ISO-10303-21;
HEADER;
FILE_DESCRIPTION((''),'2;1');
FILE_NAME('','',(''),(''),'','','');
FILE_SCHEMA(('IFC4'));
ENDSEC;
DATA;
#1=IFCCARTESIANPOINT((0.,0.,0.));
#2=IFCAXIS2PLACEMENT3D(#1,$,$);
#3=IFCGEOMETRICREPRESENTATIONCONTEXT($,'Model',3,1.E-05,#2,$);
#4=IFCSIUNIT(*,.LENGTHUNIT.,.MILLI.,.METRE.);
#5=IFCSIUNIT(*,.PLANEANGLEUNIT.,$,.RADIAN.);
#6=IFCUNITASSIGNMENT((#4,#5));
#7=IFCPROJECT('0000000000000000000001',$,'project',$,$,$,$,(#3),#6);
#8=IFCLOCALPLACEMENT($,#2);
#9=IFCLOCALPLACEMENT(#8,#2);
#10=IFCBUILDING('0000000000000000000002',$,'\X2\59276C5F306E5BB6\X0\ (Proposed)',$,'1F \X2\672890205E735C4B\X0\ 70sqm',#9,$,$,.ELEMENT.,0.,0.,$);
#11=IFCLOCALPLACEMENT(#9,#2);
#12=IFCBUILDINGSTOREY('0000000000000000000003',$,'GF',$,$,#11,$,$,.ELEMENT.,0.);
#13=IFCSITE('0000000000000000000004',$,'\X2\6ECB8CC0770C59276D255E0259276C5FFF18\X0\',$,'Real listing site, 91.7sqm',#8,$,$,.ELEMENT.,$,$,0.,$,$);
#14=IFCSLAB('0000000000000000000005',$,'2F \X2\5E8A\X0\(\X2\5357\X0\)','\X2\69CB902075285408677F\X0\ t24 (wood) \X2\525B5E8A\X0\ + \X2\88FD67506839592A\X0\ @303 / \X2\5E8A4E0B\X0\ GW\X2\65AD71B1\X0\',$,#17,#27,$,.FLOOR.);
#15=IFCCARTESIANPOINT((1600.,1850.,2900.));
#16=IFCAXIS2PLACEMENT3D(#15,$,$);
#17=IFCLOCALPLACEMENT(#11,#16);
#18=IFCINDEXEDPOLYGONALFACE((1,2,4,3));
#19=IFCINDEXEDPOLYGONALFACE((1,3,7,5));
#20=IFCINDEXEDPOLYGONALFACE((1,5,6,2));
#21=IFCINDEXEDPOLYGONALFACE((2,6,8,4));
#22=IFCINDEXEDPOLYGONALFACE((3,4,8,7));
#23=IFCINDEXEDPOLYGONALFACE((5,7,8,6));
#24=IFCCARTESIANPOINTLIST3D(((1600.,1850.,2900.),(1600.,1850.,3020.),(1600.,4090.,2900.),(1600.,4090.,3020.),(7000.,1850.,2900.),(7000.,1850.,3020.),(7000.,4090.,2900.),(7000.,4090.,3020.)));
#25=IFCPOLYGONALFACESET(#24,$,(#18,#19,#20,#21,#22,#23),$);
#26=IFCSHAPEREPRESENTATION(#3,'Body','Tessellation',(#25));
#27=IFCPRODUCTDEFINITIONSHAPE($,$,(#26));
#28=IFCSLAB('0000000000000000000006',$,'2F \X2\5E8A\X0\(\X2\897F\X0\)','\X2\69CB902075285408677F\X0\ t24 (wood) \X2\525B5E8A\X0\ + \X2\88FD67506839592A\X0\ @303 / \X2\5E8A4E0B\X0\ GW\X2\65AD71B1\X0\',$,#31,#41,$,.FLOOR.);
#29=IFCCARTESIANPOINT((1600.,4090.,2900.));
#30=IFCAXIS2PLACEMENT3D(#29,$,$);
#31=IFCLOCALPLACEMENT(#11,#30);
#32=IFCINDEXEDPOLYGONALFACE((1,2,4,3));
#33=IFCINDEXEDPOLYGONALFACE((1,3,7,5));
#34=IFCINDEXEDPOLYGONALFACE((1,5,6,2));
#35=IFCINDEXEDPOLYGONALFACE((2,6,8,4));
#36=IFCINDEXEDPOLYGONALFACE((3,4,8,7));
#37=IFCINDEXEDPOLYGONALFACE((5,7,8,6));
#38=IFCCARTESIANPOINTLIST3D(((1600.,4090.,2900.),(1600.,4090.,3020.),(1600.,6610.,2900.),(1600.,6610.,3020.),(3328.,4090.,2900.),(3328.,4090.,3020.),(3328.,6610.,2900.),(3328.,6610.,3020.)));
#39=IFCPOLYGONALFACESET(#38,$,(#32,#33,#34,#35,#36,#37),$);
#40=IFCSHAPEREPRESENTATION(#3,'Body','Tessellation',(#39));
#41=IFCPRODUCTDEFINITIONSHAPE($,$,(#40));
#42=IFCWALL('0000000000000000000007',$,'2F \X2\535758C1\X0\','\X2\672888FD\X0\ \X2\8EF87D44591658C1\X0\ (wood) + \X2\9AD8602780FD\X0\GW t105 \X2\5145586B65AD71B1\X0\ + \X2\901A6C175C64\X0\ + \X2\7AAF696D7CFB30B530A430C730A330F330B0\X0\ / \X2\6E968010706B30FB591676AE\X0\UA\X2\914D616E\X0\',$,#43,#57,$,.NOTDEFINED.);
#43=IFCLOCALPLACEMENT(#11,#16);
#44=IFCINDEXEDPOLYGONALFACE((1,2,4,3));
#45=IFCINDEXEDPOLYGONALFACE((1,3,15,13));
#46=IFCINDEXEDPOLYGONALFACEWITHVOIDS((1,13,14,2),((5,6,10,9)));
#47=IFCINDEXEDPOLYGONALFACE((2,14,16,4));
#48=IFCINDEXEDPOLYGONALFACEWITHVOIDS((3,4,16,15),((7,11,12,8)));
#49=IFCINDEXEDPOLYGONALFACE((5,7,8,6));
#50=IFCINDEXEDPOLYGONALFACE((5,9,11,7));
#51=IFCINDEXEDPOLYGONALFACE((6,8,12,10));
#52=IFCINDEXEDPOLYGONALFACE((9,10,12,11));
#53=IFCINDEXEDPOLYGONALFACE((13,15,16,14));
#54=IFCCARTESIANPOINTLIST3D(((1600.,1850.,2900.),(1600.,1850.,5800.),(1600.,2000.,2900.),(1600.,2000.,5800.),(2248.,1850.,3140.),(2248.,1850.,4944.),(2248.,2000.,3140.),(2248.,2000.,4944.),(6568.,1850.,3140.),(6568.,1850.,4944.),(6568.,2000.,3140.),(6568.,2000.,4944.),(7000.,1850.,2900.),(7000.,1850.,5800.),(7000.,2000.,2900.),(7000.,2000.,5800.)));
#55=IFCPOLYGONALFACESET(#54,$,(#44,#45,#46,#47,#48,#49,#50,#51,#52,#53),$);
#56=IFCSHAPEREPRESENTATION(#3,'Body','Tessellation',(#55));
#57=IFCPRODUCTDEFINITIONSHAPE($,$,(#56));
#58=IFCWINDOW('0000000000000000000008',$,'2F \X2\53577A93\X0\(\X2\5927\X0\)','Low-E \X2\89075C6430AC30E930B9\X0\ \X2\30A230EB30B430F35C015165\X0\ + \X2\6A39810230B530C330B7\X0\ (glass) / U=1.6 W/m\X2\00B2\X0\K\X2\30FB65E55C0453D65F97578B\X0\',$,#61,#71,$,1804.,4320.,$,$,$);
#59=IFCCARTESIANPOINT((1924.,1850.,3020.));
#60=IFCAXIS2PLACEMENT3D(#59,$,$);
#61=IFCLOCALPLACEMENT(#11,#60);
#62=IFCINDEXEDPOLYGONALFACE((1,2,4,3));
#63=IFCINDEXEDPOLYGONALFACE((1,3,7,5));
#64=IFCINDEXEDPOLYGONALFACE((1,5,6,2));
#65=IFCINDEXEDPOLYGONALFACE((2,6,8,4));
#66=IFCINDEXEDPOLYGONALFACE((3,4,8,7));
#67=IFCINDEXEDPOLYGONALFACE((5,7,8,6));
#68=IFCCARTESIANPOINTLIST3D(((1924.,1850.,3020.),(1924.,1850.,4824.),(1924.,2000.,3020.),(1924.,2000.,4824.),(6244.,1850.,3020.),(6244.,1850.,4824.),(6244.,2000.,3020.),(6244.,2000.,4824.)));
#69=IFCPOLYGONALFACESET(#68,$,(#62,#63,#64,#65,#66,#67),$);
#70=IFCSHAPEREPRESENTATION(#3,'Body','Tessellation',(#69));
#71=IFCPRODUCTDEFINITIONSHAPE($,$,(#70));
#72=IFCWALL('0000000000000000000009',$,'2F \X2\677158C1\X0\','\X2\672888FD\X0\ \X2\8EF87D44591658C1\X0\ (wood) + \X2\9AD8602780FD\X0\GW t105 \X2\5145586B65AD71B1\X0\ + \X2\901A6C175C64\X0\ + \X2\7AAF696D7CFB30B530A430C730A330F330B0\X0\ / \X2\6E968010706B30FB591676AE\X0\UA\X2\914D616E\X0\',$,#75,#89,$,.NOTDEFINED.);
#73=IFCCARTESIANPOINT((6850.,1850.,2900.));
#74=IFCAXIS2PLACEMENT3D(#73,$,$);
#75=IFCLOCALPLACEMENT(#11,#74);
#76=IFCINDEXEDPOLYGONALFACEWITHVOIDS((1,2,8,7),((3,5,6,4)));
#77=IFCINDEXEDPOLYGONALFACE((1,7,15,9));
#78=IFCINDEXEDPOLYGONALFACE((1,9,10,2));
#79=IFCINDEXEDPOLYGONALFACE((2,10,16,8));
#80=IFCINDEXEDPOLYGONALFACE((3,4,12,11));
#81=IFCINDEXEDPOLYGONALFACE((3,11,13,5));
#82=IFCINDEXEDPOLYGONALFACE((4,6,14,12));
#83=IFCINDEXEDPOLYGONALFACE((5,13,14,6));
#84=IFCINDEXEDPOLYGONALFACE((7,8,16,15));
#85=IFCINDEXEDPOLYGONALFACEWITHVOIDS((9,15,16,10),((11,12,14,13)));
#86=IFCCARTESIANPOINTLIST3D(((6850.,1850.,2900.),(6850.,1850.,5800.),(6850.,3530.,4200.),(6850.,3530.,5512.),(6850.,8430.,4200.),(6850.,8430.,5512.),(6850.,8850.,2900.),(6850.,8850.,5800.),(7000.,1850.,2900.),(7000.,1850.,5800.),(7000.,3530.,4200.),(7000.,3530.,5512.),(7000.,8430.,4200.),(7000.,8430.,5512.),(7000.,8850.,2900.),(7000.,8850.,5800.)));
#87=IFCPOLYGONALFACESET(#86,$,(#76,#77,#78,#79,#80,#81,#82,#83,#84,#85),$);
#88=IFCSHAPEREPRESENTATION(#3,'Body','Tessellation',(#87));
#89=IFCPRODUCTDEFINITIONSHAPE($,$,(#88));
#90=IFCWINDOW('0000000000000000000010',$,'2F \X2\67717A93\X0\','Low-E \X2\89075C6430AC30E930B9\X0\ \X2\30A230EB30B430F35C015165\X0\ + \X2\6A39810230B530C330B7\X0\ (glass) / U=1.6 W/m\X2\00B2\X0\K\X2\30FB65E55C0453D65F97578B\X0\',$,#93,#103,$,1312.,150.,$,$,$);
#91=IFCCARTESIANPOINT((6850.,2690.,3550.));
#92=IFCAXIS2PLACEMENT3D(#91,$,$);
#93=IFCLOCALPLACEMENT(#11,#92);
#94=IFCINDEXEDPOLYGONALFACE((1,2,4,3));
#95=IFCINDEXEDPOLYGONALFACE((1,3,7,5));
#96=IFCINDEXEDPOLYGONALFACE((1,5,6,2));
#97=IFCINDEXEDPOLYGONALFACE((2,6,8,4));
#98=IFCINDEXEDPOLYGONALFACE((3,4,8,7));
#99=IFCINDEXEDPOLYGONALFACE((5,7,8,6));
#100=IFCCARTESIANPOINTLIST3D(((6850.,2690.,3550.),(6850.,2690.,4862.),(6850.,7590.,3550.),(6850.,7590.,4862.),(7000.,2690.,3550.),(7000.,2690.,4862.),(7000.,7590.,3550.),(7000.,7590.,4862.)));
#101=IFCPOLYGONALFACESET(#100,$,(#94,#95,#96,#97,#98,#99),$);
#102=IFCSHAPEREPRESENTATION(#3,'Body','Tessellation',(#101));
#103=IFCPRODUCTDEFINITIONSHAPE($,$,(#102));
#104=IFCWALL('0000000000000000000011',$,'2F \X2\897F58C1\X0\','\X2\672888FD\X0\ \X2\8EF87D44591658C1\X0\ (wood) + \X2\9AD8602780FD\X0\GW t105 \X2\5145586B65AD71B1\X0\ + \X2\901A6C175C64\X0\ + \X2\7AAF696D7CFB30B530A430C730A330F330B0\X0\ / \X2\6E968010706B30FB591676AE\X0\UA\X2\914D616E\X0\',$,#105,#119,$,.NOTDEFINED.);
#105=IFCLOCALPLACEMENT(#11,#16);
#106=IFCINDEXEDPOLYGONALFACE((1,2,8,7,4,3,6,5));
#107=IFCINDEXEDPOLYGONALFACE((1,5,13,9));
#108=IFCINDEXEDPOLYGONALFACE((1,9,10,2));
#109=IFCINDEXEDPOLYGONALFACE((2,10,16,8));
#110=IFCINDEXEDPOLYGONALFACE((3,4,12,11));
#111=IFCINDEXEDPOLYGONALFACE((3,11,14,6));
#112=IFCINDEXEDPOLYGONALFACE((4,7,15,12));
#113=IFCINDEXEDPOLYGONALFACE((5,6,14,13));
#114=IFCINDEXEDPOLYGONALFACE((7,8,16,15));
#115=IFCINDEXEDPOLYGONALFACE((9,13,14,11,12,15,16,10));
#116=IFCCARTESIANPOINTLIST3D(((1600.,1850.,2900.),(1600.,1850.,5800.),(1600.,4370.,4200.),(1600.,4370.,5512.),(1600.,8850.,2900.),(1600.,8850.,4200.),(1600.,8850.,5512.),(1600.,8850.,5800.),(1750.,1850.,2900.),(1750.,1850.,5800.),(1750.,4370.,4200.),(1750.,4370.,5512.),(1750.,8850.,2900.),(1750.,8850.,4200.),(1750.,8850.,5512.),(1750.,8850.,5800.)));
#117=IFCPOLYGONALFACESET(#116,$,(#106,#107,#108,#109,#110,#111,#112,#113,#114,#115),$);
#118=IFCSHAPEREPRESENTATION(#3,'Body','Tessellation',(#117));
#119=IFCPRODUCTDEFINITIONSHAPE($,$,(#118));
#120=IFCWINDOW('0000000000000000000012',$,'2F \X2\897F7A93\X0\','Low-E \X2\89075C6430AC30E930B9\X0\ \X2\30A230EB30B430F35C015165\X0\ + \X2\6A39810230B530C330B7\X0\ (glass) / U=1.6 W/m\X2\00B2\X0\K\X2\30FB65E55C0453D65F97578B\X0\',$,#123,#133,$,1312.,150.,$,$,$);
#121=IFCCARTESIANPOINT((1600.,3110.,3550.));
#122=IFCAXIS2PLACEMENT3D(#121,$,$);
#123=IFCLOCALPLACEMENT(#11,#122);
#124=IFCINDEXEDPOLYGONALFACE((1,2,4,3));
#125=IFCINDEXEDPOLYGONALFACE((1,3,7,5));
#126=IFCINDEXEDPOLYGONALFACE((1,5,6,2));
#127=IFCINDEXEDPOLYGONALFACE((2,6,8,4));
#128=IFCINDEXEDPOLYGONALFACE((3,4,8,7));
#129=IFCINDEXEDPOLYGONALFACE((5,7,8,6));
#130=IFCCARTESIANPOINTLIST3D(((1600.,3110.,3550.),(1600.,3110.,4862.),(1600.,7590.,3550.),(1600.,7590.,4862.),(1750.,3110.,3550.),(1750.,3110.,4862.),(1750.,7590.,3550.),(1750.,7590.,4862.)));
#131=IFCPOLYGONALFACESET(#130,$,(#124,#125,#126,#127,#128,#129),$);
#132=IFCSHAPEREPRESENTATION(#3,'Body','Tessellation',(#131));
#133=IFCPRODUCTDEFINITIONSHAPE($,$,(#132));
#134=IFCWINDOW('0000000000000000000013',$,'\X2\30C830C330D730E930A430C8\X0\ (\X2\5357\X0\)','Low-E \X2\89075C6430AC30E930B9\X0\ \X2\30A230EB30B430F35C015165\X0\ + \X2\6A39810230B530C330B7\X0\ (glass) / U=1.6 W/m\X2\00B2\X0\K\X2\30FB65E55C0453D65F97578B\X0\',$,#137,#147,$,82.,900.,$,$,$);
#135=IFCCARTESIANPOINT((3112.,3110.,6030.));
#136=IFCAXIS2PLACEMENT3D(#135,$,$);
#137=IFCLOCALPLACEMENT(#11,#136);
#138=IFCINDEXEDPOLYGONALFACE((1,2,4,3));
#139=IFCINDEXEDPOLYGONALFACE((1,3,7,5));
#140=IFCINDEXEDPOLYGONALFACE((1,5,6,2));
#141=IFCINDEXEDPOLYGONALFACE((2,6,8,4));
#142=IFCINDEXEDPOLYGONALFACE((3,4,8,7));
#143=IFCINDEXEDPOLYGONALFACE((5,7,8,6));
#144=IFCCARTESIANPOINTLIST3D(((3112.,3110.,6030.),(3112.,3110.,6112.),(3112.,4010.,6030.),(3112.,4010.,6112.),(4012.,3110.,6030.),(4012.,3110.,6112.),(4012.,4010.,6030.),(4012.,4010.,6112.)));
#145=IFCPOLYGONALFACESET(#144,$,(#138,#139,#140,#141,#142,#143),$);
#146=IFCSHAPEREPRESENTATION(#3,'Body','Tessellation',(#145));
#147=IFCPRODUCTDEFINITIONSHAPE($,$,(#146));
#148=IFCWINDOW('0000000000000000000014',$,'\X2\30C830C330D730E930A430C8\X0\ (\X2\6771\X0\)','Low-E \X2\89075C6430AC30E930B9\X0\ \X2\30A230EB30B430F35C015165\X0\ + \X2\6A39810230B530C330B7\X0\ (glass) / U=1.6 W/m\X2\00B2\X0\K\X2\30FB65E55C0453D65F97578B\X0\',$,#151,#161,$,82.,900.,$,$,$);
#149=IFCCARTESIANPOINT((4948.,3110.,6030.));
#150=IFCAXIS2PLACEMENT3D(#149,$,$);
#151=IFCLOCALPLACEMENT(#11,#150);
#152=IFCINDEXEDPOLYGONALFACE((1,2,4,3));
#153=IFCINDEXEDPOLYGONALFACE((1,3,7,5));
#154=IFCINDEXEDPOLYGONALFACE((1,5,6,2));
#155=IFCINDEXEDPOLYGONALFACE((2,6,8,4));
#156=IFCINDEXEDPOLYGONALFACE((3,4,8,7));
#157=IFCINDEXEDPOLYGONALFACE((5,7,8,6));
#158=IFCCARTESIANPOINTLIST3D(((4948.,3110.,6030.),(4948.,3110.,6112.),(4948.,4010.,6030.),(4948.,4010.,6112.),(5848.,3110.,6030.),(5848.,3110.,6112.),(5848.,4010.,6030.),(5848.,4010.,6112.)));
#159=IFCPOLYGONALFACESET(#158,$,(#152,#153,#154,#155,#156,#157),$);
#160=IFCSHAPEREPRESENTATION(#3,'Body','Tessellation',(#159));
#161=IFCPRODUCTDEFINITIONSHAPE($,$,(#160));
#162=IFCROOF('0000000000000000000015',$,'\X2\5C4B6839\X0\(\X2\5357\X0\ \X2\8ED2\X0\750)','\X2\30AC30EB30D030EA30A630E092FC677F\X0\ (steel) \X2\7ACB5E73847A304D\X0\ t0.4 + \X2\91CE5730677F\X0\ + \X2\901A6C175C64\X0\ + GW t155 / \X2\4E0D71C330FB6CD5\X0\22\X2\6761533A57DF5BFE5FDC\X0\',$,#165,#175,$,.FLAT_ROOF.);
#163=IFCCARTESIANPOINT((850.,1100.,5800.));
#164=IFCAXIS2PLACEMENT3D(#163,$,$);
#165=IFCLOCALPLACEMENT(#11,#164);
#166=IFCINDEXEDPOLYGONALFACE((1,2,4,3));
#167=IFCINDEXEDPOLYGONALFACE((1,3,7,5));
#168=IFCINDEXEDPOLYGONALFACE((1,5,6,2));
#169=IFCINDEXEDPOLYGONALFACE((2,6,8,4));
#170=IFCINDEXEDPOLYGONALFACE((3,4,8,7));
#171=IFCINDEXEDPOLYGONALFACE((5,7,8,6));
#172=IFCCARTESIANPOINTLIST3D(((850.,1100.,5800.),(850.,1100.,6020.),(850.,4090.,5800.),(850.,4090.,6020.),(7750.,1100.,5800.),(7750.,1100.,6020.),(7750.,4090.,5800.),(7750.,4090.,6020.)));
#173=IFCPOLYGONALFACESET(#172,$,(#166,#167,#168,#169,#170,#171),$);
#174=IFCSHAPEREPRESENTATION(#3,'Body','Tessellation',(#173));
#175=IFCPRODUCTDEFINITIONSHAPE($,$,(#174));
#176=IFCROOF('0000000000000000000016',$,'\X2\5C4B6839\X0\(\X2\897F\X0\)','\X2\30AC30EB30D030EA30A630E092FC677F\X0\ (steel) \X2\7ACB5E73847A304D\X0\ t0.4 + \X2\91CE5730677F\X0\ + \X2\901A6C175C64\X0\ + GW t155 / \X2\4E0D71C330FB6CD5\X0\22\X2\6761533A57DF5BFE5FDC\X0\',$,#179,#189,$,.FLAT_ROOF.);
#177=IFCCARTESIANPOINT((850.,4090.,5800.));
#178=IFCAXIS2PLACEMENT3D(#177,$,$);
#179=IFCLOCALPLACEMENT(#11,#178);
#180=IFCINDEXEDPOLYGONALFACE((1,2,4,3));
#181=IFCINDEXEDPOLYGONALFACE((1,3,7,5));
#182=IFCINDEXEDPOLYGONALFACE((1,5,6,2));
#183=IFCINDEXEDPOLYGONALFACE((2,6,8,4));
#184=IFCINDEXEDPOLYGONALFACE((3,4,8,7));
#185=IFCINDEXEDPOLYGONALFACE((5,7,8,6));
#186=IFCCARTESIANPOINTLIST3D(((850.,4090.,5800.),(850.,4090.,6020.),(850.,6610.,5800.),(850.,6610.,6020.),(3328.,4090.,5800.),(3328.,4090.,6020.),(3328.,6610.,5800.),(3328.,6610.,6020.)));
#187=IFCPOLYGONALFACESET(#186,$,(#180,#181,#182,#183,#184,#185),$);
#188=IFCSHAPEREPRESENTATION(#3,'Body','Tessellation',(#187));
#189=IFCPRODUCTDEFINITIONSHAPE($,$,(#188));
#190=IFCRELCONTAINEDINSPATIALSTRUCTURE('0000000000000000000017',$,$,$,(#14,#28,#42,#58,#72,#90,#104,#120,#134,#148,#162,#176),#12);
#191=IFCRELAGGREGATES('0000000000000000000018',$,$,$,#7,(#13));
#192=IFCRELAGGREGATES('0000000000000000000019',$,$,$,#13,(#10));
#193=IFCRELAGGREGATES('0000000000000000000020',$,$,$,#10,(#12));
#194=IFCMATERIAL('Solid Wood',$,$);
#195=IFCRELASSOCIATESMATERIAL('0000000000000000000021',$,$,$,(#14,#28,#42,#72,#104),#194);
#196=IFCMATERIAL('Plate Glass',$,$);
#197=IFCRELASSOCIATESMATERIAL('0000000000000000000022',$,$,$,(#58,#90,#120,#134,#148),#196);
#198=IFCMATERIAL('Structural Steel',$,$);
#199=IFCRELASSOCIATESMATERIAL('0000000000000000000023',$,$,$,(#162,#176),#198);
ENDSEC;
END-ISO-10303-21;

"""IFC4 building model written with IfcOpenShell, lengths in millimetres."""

from ifc_helpers import new_model, si_unit, frame, frame_2d, origin, place, context, project, spatial, rectangle, extrude, material, element, fill, save


model = new_model("IFC4")

# Units and contexts
model_context = context("Model", 3, precision=1e-05, world=origin())
ifc_project = project(units=[si_unit("LENGTHUNIT", "METRE", prefix="MILLI"), si_unit("PLANEANGLEUNIT", "RADIAN")], contexts=[model_context])

# Site, building, storey
site_placement = place(None, origin())
site = spatial("IfcSite", under=ifc_project, at=site_placement, Name="滋賀県大津市大江８", ObjectType="Real listing site, 91.7sqm", CompositionType="ELEMENT", RefElevation=0.0)
building_placement = place(site_placement, origin())
building = spatial("IfcBuilding", under=site, at=building_placement, Name="大江の家 (Proposed)", ObjectType="1F 木造平屋 70sqm", CompositionType="ELEMENT", ElevationOfRefHeight=0.0, ElevationOfTerrain=0.0)
storey_placement = place(building_placement, origin())
storey = spatial("IfcBuildingStorey", under=building, at=storey_placement, Name="GF", CompositionType="ELEMENT", Elevation=0.0)

# Slabs
ifc_material_1 = material(Name="Solid Wood")
slab_1_placement = place(storey_placement, frame((1600.0, 1850.0, 2900.0)))
element("IfcSlab", 1, at=slab_1_placement, inside=storey, material=ifc_material_1, Name="2F 床(南)", Description="構造用合板 t24 (wood) 剛床 + 製材根太 @303 / 床下 GW断熱", PredefinedType="FLOOR", context=model_context, shape_type="SweptSolid", body=[
    extrude(rectangle(XDim=5400.0, YDim=2240.0, at=frame_2d((2700.0, 1120.0))), frame((1600.0, 1850.0, 2900.0)), (0.0, 0.0, 1.0), 120.0),
])
slab_2_placement = place(storey_placement, frame((1600.0, 4090.0, 2900.0)))
element("IfcSlab", 2, at=slab_2_placement, inside=storey, material=ifc_material_1, Name="2F 床(西)", Description="構造用合板 t24 (wood) 剛床 + 製材根太 @303 / 床下 GW断熱", PredefinedType="FLOOR", context=model_context, shape_type="SweptSolid", body=[
    extrude(rectangle(XDim=1728.0, YDim=2520.0, at=frame_2d((864.0, 1260.0))), frame((1600.0, 4090.0, 2900.0)), (0.0, 0.0, 1.0), 120.0),
])

# Walls, openings, windows
wall_1_placement = place(storey_placement, frame((1600.0, 1850.0, 2900.0)))
wall_1 = element("IfcWall", 3, at=wall_1_placement, inside=storey, material=ifc_material_1, Name="2F 南壁", Description="木製 軸組外壁 (wood) + 高性能GW t105 充填断熱 + 通気層 + 窯業系サイディング / 準耐火・外皮UA配慮", PredefinedType="NOTDEFINED", context=model_context, shape_type="SweptSolid", body=[
    extrude(rectangle(XDim=5400.0, YDim=150.0, at=frame_2d((2700.0, 75.0))), frame((1600.0, 1850.0, 2900.0)), (0.0, 0.0, 1.0), 2900.0),
])
opening_1_placement = place(storey_placement, frame((1924.0, 1850.0, 3020.0)))
opening_1 = element("IfcOpeningElement", 4, at=opening_1_placement, cuts=wall_1, PredefinedType="NOTDEFINED", context=model_context, shape_type="SweptSolid", body=[
    extrude(rectangle(XDim=4320.0, YDim=150.0, at=frame_2d((2160.0, 75.0))), frame((1924.0, 1850.0, 3020.0)), (0.0, 0.0, 1.0), 1804.0),
])
ifc_material_2 = material(Name="Plate Glass")
window_1_placement = place(storey_placement, frame((1924.0, 1850.0, 3020.0)))
window_1 = element("IfcWindow", 5, at=window_1_placement, inside=storey, material=ifc_material_2, Name="2F 南窓(大)", Description="Low-E 複層ガラス アルゴン封入 + 樹脂サッシ (glass) / U=1.6 W/m²K・日射取得型", OverallHeight=1804.0, OverallWidth=4320.0, context=model_context, shape_type="SweptSolid", body=[
    extrude(rectangle(XDim=4320.0, YDim=150.0, at=frame_2d((2160.0, 75.0))), frame((1924.0, 1850.0, 3020.0)), (0.0, 0.0, 1.0), 1804.0),
])
fill(opening_1, window_1)
wall_2_placement = place(storey_placement, frame((6850.0, 1850.0, 2900.0)))
wall_2 = element("IfcWall", 6, at=wall_2_placement, inside=storey, material=ifc_material_1, Name="2F 東壁", Description="木製 軸組外壁 (wood) + 高性能GW t105 充填断熱 + 通気層 + 窯業系サイディング / 準耐火・外皮UA配慮", PredefinedType="NOTDEFINED", context=model_context, shape_type="SweptSolid", body=[
    extrude(rectangle(XDim=150.0, YDim=7000.0, at=frame_2d((75.0, 3500.0))), frame((6850.0, 1850.0, 2900.0)), (0.0, 0.0, 1.0), 2900.0),
])
opening_2_placement = place(storey_placement, frame((6850.0, 2690.0, 3550.0)))
opening_2 = element("IfcOpeningElement", 7, at=opening_2_placement, cuts=wall_2, PredefinedType="NOTDEFINED", context=model_context, shape_type="SweptSolid", body=[
    extrude(rectangle(XDim=150.0, YDim=4900.0, at=frame_2d((75.0, 2450.0))), frame((6850.0, 2690.0, 3550.0)), (0.0, 0.0, 1.0), 1312.0),
])
window_2_placement = place(storey_placement, frame((6850.0, 2690.0, 3550.0)))
window_2 = element("IfcWindow", 8, at=window_2_placement, inside=storey, material=ifc_material_2, Name="2F 東窓", Description="Low-E 複層ガラス アルゴン封入 + 樹脂サッシ (glass) / U=1.6 W/m²K・日射取得型", OverallHeight=1312.0, OverallWidth=150.0, context=model_context, shape_type="SweptSolid", body=[
    extrude(rectangle(XDim=150.0, YDim=4900.0, at=frame_2d((75.0, 2450.0))), frame((6850.0, 2690.0, 3550.0)), (0.0, 0.0, 1.0), 1312.0),
])
fill(opening_2, window_2)
wall_3_placement = place(storey_placement, frame((1600.0, 1850.0, 2900.0)))
wall_3 = element("IfcWall", 9, at=wall_3_placement, inside=storey, material=ifc_material_1, Name="2F 西壁", Description="木製 軸組外壁 (wood) + 高性能GW t105 充填断熱 + 通気層 + 窯業系サイディング / 準耐火・外皮UA配慮", PredefinedType="NOTDEFINED", context=model_context, shape_type="SweptSolid", body=[
    extrude(rectangle(XDim=150.0, YDim=7000.0, at=frame_2d((75.0, 3500.0))), frame((1600.0, 1850.0, 2900.0)), (0.0, 0.0, 1.0), 2900.0),
])
opening_3_placement = place(storey_placement, frame((1600.0, 3110.0, 3550.0)))
opening_3 = element("IfcOpeningElement", 10, at=opening_3_placement, cuts=wall_3, PredefinedType="NOTDEFINED", context=model_context, shape_type="SweptSolid", body=[
    extrude(rectangle(XDim=150.0, YDim=4480.0, at=frame_2d((75.0, 2240.0))), frame((1600.0, 3110.0, 3550.0)), (0.0, 0.0, 1.0), 1312.0),
])
window_3_placement = place(storey_placement, frame((1600.0, 3110.0, 3550.0)))
window_3 = element("IfcWindow", 11, at=window_3_placement, inside=storey, material=ifc_material_2, Name="2F 西窓", Description="Low-E 複層ガラス アルゴン封入 + 樹脂サッシ (glass) / U=1.6 W/m²K・日射取得型", OverallHeight=1312.0, OverallWidth=150.0, context=model_context, shape_type="SweptSolid", body=[
    extrude(rectangle(XDim=150.0, YDim=4480.0, at=frame_2d((75.0, 2240.0))), frame((1600.0, 3110.0, 3550.0)), (0.0, 0.0, 1.0), 1312.0),
])
fill(opening_3, window_3)

# Windows
window_4_placement = place(storey_placement, frame((3112.0, 3110.0, 6030.0)))
element("IfcWindow", 12, at=window_4_placement, inside=storey, material=ifc_material_2, Name="トップライト (南)", Description="Low-E 複層ガラス アルゴン封入 + 樹脂サッシ (glass) / U=1.6 W/m²K・日射取得型", OverallHeight=82.0, OverallWidth=900.0, context=model_context, shape_type="SweptSolid", body=[
    extrude(rectangle(XDim=900.0, YDim=900.0, at=frame_2d((450.0, 450.0))), frame((3112.0, 3110.0, 6030.0)), (0.0, 0.0, 1.0), 82.0),
])
window_5_placement = place(storey_placement, frame((4948.0, 3110.0, 6030.0)))
element("IfcWindow", 13, at=window_5_placement, inside=storey, material=ifc_material_2, Name="トップライト (東)", Description="Low-E 複層ガラス アルゴン封入 + 樹脂サッシ (glass) / U=1.6 W/m²K・日射取得型", OverallHeight=82.0, OverallWidth=900.0, context=model_context, shape_type="SweptSolid", body=[
    extrude(rectangle(XDim=900.0, YDim=900.0, at=frame_2d((450.0, 450.0))), frame((4948.0, 3110.0, 6030.0)), (0.0, 0.0, 1.0), 82.0),
])

# Roofs
ifc_material_3 = material(Name="Structural Steel")
roof_1_placement = place(storey_placement, frame((850.0, 1100.0, 5800.0)))
element("IfcRoof", 14, at=roof_1_placement, inside=storey, material=ifc_material_3, Name="屋根(南 軒750)", Description="ガルバリウム鋼板 (steel) 立平葺き t0.4 + 野地板 + 通気層 + GW t155 / 不燃・法22条区域対応", PredefinedType="FLAT_ROOF", context=model_context, shape_type="SweptSolid", body=[
    extrude(rectangle(XDim=6900.0, YDim=2990.0, at=frame_2d((3450.0, 1495.0))), frame((850.0, 1100.0, 5800.0)), (0.0, 0.0, 1.0), 220.0),
])
roof_2_placement = place(storey_placement, frame((850.0, 4090.0, 5800.0)))
element("IfcRoof", 15, at=roof_2_placement, inside=storey, material=ifc_material_3, Name="屋根(西)", Description="ガルバリウム鋼板 (steel) 立平葺き t0.4 + 野地板 + 通気層 + GW t155 / 不燃・法22条区域対応", PredefinedType="FLAT_ROOF", context=model_context, shape_type="SweptSolid", body=[
    extrude(rectangle(XDim=2478.0, YDim=2520.0, at=frame_2d((1239.0, 1260.0))), frame((850.0, 4090.0, 5800.0)), (0.0, 0.0, 1.0), 220.0),
])

save(model, "model.ifc")
